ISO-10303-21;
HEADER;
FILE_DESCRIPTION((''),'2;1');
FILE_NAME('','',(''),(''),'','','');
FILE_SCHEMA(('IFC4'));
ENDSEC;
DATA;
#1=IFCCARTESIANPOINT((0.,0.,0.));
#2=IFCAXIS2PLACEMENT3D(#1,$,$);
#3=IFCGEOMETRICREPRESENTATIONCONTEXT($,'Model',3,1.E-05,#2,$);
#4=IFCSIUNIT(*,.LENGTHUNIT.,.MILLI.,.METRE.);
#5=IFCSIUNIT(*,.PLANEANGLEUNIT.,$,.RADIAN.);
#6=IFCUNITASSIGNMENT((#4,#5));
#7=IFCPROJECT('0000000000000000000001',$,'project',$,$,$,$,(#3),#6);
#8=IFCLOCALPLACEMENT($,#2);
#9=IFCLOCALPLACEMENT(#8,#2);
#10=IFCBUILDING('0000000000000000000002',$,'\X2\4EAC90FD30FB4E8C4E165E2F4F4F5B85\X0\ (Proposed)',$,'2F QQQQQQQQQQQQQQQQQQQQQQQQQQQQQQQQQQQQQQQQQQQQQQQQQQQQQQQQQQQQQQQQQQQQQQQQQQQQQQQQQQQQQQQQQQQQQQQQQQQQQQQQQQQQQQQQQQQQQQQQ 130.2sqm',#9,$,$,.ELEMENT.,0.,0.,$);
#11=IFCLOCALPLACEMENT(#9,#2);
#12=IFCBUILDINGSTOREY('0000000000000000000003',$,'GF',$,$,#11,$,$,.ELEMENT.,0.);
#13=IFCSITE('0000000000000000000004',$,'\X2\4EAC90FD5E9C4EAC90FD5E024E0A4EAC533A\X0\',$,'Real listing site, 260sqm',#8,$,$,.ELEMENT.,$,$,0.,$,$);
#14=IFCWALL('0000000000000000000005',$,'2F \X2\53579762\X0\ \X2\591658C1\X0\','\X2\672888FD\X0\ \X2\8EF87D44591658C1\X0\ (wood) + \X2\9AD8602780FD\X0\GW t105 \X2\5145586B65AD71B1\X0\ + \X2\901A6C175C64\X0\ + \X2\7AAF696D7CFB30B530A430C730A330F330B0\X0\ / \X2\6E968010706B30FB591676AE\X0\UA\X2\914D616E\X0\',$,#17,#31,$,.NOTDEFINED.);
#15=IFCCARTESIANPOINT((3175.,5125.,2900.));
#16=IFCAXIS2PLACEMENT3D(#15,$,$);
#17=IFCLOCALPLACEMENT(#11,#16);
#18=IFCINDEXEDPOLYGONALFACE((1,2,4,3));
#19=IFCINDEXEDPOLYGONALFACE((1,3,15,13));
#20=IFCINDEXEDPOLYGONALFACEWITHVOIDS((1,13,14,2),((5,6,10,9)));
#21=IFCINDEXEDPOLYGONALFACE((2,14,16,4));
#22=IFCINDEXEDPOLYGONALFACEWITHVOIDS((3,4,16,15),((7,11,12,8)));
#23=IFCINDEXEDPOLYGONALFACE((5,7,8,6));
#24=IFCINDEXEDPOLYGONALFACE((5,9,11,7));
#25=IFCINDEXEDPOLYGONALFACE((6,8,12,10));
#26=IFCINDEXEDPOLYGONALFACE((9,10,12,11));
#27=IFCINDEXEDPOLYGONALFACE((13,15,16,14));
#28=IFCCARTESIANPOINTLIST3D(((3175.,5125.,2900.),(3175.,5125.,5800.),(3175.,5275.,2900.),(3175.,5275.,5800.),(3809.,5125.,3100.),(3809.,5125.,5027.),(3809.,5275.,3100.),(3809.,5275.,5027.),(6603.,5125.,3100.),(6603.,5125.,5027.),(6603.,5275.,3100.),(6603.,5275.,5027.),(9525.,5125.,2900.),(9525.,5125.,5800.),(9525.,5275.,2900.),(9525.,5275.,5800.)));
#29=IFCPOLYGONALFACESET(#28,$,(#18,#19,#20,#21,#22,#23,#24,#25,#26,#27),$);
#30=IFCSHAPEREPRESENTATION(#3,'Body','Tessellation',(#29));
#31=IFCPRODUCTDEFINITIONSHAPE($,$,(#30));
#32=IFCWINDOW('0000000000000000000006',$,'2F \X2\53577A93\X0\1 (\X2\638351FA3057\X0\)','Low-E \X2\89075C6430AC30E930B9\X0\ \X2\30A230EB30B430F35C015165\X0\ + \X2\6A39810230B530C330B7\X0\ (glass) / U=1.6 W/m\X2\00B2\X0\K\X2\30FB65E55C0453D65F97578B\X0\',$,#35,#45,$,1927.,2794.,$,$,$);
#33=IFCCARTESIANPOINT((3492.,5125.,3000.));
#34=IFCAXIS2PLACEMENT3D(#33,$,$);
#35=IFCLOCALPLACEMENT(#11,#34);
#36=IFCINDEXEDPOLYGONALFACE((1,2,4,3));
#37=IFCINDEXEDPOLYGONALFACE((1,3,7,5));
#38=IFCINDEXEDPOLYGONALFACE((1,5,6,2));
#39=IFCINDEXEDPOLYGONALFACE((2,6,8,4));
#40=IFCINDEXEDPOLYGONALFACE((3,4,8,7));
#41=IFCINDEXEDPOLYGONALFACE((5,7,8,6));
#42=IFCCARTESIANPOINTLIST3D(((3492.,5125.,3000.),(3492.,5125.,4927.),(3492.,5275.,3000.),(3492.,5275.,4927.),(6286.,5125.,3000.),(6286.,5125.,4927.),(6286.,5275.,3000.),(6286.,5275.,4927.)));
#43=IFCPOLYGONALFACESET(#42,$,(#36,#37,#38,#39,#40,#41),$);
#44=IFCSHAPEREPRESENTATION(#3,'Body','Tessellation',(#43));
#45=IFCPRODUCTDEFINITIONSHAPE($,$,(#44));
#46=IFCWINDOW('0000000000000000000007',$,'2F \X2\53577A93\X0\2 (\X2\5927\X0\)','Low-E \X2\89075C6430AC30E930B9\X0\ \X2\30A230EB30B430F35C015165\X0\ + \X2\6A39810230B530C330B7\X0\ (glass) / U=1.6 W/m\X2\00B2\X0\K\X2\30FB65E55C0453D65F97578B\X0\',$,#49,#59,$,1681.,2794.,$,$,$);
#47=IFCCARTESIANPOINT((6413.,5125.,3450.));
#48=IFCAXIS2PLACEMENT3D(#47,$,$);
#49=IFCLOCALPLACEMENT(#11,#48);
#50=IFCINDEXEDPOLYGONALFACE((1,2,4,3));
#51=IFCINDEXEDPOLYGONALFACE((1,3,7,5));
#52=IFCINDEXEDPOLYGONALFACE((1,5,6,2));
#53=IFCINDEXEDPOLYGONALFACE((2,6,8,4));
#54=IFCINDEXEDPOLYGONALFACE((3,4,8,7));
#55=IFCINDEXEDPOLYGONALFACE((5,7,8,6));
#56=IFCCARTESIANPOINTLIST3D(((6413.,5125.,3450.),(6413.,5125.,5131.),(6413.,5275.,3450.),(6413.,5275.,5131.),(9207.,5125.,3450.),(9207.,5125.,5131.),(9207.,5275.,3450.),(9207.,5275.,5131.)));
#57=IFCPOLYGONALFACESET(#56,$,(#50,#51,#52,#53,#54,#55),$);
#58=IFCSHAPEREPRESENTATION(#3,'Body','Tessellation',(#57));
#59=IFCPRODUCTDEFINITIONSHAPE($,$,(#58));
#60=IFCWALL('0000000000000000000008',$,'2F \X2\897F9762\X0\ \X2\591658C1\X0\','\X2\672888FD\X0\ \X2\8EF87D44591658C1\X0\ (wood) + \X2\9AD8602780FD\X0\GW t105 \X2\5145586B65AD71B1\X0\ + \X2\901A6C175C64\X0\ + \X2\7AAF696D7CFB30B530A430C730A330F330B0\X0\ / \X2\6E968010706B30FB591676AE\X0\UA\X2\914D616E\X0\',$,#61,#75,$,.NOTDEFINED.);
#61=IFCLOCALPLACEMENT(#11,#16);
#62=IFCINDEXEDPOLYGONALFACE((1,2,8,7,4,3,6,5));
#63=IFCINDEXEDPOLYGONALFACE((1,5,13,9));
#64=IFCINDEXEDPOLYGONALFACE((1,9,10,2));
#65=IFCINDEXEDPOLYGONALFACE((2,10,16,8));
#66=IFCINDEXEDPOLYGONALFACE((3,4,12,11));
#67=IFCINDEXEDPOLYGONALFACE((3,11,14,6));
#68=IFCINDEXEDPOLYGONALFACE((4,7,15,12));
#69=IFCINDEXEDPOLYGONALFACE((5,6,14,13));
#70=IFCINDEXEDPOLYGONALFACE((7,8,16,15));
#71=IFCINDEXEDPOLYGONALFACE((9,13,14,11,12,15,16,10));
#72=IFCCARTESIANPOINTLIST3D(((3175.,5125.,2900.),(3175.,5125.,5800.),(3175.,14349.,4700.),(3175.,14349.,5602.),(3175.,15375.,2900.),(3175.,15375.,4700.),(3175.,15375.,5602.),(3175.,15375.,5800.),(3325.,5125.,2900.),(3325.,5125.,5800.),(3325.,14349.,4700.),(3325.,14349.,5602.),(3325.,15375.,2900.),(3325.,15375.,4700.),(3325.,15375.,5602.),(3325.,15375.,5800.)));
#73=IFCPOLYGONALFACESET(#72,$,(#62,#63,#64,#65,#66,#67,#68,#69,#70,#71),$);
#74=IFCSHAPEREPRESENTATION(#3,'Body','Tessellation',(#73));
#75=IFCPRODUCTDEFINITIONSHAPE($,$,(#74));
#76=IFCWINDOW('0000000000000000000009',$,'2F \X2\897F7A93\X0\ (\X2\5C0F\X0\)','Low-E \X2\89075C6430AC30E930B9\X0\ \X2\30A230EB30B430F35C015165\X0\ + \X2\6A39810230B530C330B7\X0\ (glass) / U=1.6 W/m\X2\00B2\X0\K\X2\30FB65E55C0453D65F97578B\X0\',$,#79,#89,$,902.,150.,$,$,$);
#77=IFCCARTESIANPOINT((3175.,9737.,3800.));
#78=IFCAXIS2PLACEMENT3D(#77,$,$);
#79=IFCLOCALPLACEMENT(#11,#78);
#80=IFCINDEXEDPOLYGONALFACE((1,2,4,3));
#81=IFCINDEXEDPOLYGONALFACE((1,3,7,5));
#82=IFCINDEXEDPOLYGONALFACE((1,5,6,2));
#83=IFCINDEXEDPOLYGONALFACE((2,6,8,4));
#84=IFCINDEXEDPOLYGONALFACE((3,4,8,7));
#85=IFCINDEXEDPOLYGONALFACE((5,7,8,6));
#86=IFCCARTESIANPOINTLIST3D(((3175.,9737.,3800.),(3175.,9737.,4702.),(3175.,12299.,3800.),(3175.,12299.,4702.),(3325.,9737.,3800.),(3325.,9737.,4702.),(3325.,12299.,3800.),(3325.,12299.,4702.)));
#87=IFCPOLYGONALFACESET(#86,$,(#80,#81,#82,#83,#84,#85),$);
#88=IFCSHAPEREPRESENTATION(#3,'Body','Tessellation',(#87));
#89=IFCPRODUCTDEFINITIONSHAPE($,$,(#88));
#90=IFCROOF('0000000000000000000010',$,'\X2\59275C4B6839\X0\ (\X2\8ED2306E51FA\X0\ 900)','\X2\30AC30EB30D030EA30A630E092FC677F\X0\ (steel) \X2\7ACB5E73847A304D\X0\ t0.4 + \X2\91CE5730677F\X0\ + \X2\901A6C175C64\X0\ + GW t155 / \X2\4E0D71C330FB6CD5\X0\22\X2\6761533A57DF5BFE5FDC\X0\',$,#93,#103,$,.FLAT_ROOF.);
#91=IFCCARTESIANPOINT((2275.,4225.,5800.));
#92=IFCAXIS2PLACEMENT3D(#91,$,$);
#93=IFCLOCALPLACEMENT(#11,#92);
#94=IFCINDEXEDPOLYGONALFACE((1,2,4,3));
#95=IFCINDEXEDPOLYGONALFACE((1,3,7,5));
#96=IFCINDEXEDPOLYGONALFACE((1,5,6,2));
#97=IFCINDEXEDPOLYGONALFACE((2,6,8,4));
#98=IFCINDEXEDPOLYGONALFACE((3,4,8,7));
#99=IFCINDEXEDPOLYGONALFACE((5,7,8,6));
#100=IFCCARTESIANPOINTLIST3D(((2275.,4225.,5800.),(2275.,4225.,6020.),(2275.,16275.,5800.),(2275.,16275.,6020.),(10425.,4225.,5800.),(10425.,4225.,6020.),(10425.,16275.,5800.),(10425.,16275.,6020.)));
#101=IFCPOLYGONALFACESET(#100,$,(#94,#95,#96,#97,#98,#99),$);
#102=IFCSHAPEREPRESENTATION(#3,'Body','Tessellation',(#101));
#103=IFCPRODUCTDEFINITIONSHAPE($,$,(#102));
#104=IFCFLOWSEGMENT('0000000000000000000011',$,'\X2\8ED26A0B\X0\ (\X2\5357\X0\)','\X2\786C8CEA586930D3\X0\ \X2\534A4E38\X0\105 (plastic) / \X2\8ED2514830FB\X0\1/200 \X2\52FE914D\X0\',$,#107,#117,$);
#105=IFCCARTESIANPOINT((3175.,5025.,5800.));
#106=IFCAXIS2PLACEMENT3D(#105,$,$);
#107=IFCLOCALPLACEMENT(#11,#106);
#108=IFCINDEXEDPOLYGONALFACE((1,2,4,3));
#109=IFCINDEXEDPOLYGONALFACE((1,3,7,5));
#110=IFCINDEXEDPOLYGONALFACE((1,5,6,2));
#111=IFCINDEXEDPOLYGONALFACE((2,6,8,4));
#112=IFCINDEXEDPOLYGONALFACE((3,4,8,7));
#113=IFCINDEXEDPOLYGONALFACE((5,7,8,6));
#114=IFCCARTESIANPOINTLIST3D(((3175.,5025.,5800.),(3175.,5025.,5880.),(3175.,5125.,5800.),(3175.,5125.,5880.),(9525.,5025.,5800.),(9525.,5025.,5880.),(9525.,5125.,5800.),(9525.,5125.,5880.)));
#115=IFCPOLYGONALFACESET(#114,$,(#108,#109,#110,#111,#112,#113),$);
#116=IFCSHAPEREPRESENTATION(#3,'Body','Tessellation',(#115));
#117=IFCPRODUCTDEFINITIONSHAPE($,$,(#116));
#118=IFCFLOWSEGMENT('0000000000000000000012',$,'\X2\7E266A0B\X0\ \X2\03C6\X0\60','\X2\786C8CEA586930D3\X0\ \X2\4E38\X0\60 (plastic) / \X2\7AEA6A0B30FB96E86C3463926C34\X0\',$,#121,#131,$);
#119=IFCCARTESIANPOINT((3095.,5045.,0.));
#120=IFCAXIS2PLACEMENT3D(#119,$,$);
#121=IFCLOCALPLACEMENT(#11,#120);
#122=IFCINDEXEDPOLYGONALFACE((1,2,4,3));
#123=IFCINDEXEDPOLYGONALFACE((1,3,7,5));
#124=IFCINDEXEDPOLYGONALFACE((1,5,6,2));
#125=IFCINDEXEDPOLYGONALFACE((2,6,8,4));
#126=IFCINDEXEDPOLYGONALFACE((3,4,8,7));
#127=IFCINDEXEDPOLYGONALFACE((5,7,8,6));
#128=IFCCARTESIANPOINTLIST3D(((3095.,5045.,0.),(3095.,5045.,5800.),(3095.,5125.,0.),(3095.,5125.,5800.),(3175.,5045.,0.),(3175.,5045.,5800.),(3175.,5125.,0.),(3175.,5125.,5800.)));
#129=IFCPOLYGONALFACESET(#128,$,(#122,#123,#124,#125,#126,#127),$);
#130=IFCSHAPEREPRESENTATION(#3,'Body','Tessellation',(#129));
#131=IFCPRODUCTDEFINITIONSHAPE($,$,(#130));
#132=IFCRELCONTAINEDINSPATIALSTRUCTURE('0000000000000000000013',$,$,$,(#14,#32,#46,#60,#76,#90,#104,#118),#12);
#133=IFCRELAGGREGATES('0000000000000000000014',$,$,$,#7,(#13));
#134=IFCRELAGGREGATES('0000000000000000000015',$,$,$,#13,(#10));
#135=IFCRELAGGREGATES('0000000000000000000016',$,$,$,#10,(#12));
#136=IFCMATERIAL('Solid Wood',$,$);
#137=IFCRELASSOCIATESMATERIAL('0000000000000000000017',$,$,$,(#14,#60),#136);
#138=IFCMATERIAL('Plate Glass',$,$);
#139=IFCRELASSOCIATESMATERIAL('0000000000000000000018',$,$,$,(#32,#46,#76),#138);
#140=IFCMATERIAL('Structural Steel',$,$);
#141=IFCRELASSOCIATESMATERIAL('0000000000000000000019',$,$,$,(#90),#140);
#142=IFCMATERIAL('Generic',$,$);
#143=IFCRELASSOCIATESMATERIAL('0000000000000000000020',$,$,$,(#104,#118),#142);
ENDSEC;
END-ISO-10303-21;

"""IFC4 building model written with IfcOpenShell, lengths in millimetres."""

from ifc_helpers import new_model, si_unit, frame, frame_2d, origin, place, context, project, spatial, rectangle, extrude, material, element, fill, save


model = new_model("IFC4")

# Units and contexts
model_context = context("Model", 3, precision=1e-05, world=origin())
ifc_project = project(units=[si_unit("LENGTHUNIT", "METRE", prefix="MILLI"), si_unit("PLANEANGLEUNIT", "RADIAN")], contexts=[model_context])

# Site, building, storey
site_placement = place(None, origin())
site = spatial("IfcSite", under=ifc_project, at=site_placement, Name="京都府京都市上京区", ObjectType="Real listing site, 260sqm", CompositionType="ELEMENT", RefElevation=0.0)
building_placement = place(site_placement, origin())
building = spatial("IfcBuilding", under=site, at=building_placement, Name="京都・二世帯住宅 (Proposed)", ObjectType="2F QQQQQQQQQQQQQQQQQQQQQQQQQQQQQQQQQQQQQQQQQQQQQQQQQQQQQQQQQQQQQQQQQQQQQQQQQQQQQQQQQQQQQQQQQQQQQQQQQQQQQQQQQQQQQQQQQQQQQQQQ 130.2sqm", CompositionType="ELEMENT", ElevationOfRefHeight=0.0, ElevationOfTerrain=0.0)
storey_placement = place(building_placement, origin())
storey = spatial("IfcBuildingStorey", under=building, at=storey_placement, Name="GF", CompositionType="ELEMENT", Elevation=0.0)

# Shared definitions
ifc_material_1 = material(Name="Solid Wood")

# Shared definitions
ifc_material_2 = material(Name="Plate Glass")

# Wall, openings, windows
wall_1_placement = place(storey_placement, frame((3175.0, 5125.0, 2900.0)))
wall_1 = element("IfcWall", 1, at=wall_1_placement, inside=storey, material=ifc_material_1, Name="2F 南面 外壁", Description="木製 軸組外壁 (wood) + 高性能GW t105 充填断熱 + 通気層 + 窯業系サイディング / 準耐火・外皮UA配慮", PredefinedType="NOTDEFINED", context=model_context, shape_type="SweptSolid", body=[
    extrude(rectangle(XDim=6350.0, YDim=150.0, at=frame_2d((3175.0, 75.0))), frame((3175.0, 5125.0, 2900.0)), (0.0, 0.0, 1.0), 2900.0),
])
opening_1_placement = place(storey_placement, frame((3492.0, 5125.0, 3000.0)))
opening_1 = element("IfcOpeningElement", 2, at=opening_1_placement, cuts=wall_1, PredefinedType="NOTDEFINED", context=model_context, shape_type="SweptSolid", body=[
    extrude(rectangle(XDim=2794.0, YDim=150.0, at=frame_2d((1397.0, 75.0))), frame((3492.0, 5125.0, 3000.0)), (0.0, 0.0, 1.0), 1927.0),
])
opening_2_placement = place(storey_placement, frame((6413.0, 5125.0, 3450.0)))
opening_2 = element("IfcOpeningElement", 3, at=opening_2_placement, cuts=wall_1, PredefinedType="NOTDEFINED", context=model_context, shape_type="SweptSolid", body=[
    extrude(rectangle(XDim=2794.0, YDim=150.0, at=frame_2d((1397.0, 75.0))), frame((6413.0, 5125.0, 3450.0)), (0.0, 0.0, 1.0), 1681.0),
])
window_1_placement = place(storey_placement, frame((3492.0, 5125.0, 3000.0)))
window_1 = element("IfcWindow", 4, at=window_1_placement, inside=storey, material=ifc_material_2, Name="2F 南窓1 (掃出し)", Description="Low-E 複層ガラス アルゴン封入 + 樹脂サッシ (glass) / U=1.6 W/m²K・日射取得型", OverallHeight=1927.0, OverallWidth=2794.0, context=model_context, shape_type="SweptSolid", body=[
    extrude(rectangle(XDim=2794.0, YDim=150.0, at=frame_2d((1397.0, 75.0))), frame((3492.0, 5125.0, 3000.0)), (0.0, 0.0, 1.0), 1927.0),
])
fill(opening_1, window_1)
window_2_placement = place(storey_placement, frame((6413.0, 5125.0, 3450.0)))
window_2 = element("IfcWindow", 5, at=window_2_placement, inside=storey, material=ifc_material_2, Name="2F 南窓2 (大)", Description="Low-E 複層ガラス アルゴン封入 + 樹脂サッシ (glass) / U=1.6 W/m²K・日射取得型", OverallHeight=1681.0, OverallWidth=2794.0, context=model_context, shape_type="SweptSolid", body=[
    extrude(rectangle(XDim=2794.0, YDim=150.0, at=frame_2d((1397.0, 75.0))), frame((6413.0, 5125.0, 3450.0)), (0.0, 0.0, 1.0), 1681.0),
])
fill(opening_2, window_2)

# Wall, opening, window
wall_2_placement = place(storey_placement, frame((3175.0, 5125.0, 2900.0)))
wall_2 = element("IfcWall", 6, at=wall_2_placement, inside=storey, material=ifc_material_1, Name="2F 西面 外壁", Description="木製 軸組外壁 (wood) + 高性能GW t105 充填断熱 + 通気層 + 窯業系サイディング / 準耐火・外皮UA配慮", PredefinedType="NOTDEFINED", context=model_context, shape_type="SweptSolid", body=[
    extrude(rectangle(XDim=150.0, YDim=10250.0, at=frame_2d((75.0, 5125.0))), frame((3175.0, 5125.0, 2900.0)), (0.0, 0.0, 1.0), 2900.0),
])
opening_3_placement = place(storey_placement, frame((3175.0, 9737.0, 3800.0)))
opening_3 = element("IfcOpeningElement", 7, at=opening_3_placement, cuts=wall_2, PredefinedType="NOTDEFINED", context=model_context, shape_type="SweptSolid", body=[
    extrude(rectangle(XDim=150.0, YDim=2562.0, at=frame_2d((75.0, 1281.0))), frame((3175.0, 9737.0, 3800.0)), (0.0, 0.0, 1.0), 902.0),
])
window_3_placement = place(storey_placement, frame((3175.0, 9737.0, 3800.0)))
window_3 = element("IfcWindow", 8, at=window_3_placement, inside=storey, material=ifc_material_2, Name="2F 西窓 (小)", Description="Low-E 複層ガラス アルゴン封入 + 樹脂サッシ (glass) / U=1.6 W/m²K・日射取得型", OverallHeight=902.0, OverallWidth=150.0, context=model_context, shape_type="SweptSolid", body=[
    extrude(rectangle(XDim=150.0, YDim=2562.0, at=frame_2d((75.0, 1281.0))), frame((3175.0, 9737.0, 3800.0)), (0.0, 0.0, 1.0), 902.0),
])
fill(opening_3, window_3)

# Roof
ifc_material_3 = material(Name="Structural Steel")
roof_placement = place(storey_placement, frame((2275.0, 4225.0, 5800.0)))
element("IfcRoof", 9, at=roof_placement, inside=storey, material=ifc_material_3, Name="大屋根 (軒の出 900)", Description="ガルバリウム鋼板 (steel) 立平葺き t0.4 + 野地板 + 通気層 + GW t155 / 不燃・法22条区域対応", PredefinedType="FLAT_ROOF", context=model_context, shape_type="SweptSolid", body=[
    extrude(rectangle(XDim=8150.0, YDim=12050.0, at=frame_2d((4075.0, 6025.0))), frame((2275.0, 4225.0, 5800.0)), (0.0, 0.0, 1.0), 220.0),
])

# Flow segments
ifc_material_4 = material(Name="Generic")
flow_segment_1_placement = place(storey_placement, frame((3175.0, 5025.0, 5800.0)))
element("IfcFlowSegment", 10, at=flow_segment_1_placement, inside=storey, material=ifc_material_4, Name="軒樋 (南)", Description="硬質塩ビ 半丸105 (plastic) / 軒先・1/200 勾配", context=model_context, shape_type="SweptSolid", body=[
    extrude(rectangle(XDim=6350.0, YDim=100.0, at=frame_2d((3175.0, 50.0))), frame((3175.0, 5025.0, 5800.0)), (0.0, 0.0, 1.0), 80.0),
])
flow_segment_2_placement = place(storey_placement, frame((3095.0, 5045.0, 0.0)))
element("IfcFlowSegment", 11, at=flow_segment_2_placement, inside=storey, material=ifc_material_4, Name="縦樋 φ60", Description="硬質塩ビ 丸60 (plastic) / 竪樋・雨水排水", context=model_context, shape_type="SweptSolid", body=[
    extrude(rectangle(XDim=80.0, YDim=80.0, at=frame_2d((40.0, 40.0))), frame((3095.0, 5045.0, 0.0)), (0.0, 0.0, 1.0), 5800.0),
])

save(model, "model.ifc")
